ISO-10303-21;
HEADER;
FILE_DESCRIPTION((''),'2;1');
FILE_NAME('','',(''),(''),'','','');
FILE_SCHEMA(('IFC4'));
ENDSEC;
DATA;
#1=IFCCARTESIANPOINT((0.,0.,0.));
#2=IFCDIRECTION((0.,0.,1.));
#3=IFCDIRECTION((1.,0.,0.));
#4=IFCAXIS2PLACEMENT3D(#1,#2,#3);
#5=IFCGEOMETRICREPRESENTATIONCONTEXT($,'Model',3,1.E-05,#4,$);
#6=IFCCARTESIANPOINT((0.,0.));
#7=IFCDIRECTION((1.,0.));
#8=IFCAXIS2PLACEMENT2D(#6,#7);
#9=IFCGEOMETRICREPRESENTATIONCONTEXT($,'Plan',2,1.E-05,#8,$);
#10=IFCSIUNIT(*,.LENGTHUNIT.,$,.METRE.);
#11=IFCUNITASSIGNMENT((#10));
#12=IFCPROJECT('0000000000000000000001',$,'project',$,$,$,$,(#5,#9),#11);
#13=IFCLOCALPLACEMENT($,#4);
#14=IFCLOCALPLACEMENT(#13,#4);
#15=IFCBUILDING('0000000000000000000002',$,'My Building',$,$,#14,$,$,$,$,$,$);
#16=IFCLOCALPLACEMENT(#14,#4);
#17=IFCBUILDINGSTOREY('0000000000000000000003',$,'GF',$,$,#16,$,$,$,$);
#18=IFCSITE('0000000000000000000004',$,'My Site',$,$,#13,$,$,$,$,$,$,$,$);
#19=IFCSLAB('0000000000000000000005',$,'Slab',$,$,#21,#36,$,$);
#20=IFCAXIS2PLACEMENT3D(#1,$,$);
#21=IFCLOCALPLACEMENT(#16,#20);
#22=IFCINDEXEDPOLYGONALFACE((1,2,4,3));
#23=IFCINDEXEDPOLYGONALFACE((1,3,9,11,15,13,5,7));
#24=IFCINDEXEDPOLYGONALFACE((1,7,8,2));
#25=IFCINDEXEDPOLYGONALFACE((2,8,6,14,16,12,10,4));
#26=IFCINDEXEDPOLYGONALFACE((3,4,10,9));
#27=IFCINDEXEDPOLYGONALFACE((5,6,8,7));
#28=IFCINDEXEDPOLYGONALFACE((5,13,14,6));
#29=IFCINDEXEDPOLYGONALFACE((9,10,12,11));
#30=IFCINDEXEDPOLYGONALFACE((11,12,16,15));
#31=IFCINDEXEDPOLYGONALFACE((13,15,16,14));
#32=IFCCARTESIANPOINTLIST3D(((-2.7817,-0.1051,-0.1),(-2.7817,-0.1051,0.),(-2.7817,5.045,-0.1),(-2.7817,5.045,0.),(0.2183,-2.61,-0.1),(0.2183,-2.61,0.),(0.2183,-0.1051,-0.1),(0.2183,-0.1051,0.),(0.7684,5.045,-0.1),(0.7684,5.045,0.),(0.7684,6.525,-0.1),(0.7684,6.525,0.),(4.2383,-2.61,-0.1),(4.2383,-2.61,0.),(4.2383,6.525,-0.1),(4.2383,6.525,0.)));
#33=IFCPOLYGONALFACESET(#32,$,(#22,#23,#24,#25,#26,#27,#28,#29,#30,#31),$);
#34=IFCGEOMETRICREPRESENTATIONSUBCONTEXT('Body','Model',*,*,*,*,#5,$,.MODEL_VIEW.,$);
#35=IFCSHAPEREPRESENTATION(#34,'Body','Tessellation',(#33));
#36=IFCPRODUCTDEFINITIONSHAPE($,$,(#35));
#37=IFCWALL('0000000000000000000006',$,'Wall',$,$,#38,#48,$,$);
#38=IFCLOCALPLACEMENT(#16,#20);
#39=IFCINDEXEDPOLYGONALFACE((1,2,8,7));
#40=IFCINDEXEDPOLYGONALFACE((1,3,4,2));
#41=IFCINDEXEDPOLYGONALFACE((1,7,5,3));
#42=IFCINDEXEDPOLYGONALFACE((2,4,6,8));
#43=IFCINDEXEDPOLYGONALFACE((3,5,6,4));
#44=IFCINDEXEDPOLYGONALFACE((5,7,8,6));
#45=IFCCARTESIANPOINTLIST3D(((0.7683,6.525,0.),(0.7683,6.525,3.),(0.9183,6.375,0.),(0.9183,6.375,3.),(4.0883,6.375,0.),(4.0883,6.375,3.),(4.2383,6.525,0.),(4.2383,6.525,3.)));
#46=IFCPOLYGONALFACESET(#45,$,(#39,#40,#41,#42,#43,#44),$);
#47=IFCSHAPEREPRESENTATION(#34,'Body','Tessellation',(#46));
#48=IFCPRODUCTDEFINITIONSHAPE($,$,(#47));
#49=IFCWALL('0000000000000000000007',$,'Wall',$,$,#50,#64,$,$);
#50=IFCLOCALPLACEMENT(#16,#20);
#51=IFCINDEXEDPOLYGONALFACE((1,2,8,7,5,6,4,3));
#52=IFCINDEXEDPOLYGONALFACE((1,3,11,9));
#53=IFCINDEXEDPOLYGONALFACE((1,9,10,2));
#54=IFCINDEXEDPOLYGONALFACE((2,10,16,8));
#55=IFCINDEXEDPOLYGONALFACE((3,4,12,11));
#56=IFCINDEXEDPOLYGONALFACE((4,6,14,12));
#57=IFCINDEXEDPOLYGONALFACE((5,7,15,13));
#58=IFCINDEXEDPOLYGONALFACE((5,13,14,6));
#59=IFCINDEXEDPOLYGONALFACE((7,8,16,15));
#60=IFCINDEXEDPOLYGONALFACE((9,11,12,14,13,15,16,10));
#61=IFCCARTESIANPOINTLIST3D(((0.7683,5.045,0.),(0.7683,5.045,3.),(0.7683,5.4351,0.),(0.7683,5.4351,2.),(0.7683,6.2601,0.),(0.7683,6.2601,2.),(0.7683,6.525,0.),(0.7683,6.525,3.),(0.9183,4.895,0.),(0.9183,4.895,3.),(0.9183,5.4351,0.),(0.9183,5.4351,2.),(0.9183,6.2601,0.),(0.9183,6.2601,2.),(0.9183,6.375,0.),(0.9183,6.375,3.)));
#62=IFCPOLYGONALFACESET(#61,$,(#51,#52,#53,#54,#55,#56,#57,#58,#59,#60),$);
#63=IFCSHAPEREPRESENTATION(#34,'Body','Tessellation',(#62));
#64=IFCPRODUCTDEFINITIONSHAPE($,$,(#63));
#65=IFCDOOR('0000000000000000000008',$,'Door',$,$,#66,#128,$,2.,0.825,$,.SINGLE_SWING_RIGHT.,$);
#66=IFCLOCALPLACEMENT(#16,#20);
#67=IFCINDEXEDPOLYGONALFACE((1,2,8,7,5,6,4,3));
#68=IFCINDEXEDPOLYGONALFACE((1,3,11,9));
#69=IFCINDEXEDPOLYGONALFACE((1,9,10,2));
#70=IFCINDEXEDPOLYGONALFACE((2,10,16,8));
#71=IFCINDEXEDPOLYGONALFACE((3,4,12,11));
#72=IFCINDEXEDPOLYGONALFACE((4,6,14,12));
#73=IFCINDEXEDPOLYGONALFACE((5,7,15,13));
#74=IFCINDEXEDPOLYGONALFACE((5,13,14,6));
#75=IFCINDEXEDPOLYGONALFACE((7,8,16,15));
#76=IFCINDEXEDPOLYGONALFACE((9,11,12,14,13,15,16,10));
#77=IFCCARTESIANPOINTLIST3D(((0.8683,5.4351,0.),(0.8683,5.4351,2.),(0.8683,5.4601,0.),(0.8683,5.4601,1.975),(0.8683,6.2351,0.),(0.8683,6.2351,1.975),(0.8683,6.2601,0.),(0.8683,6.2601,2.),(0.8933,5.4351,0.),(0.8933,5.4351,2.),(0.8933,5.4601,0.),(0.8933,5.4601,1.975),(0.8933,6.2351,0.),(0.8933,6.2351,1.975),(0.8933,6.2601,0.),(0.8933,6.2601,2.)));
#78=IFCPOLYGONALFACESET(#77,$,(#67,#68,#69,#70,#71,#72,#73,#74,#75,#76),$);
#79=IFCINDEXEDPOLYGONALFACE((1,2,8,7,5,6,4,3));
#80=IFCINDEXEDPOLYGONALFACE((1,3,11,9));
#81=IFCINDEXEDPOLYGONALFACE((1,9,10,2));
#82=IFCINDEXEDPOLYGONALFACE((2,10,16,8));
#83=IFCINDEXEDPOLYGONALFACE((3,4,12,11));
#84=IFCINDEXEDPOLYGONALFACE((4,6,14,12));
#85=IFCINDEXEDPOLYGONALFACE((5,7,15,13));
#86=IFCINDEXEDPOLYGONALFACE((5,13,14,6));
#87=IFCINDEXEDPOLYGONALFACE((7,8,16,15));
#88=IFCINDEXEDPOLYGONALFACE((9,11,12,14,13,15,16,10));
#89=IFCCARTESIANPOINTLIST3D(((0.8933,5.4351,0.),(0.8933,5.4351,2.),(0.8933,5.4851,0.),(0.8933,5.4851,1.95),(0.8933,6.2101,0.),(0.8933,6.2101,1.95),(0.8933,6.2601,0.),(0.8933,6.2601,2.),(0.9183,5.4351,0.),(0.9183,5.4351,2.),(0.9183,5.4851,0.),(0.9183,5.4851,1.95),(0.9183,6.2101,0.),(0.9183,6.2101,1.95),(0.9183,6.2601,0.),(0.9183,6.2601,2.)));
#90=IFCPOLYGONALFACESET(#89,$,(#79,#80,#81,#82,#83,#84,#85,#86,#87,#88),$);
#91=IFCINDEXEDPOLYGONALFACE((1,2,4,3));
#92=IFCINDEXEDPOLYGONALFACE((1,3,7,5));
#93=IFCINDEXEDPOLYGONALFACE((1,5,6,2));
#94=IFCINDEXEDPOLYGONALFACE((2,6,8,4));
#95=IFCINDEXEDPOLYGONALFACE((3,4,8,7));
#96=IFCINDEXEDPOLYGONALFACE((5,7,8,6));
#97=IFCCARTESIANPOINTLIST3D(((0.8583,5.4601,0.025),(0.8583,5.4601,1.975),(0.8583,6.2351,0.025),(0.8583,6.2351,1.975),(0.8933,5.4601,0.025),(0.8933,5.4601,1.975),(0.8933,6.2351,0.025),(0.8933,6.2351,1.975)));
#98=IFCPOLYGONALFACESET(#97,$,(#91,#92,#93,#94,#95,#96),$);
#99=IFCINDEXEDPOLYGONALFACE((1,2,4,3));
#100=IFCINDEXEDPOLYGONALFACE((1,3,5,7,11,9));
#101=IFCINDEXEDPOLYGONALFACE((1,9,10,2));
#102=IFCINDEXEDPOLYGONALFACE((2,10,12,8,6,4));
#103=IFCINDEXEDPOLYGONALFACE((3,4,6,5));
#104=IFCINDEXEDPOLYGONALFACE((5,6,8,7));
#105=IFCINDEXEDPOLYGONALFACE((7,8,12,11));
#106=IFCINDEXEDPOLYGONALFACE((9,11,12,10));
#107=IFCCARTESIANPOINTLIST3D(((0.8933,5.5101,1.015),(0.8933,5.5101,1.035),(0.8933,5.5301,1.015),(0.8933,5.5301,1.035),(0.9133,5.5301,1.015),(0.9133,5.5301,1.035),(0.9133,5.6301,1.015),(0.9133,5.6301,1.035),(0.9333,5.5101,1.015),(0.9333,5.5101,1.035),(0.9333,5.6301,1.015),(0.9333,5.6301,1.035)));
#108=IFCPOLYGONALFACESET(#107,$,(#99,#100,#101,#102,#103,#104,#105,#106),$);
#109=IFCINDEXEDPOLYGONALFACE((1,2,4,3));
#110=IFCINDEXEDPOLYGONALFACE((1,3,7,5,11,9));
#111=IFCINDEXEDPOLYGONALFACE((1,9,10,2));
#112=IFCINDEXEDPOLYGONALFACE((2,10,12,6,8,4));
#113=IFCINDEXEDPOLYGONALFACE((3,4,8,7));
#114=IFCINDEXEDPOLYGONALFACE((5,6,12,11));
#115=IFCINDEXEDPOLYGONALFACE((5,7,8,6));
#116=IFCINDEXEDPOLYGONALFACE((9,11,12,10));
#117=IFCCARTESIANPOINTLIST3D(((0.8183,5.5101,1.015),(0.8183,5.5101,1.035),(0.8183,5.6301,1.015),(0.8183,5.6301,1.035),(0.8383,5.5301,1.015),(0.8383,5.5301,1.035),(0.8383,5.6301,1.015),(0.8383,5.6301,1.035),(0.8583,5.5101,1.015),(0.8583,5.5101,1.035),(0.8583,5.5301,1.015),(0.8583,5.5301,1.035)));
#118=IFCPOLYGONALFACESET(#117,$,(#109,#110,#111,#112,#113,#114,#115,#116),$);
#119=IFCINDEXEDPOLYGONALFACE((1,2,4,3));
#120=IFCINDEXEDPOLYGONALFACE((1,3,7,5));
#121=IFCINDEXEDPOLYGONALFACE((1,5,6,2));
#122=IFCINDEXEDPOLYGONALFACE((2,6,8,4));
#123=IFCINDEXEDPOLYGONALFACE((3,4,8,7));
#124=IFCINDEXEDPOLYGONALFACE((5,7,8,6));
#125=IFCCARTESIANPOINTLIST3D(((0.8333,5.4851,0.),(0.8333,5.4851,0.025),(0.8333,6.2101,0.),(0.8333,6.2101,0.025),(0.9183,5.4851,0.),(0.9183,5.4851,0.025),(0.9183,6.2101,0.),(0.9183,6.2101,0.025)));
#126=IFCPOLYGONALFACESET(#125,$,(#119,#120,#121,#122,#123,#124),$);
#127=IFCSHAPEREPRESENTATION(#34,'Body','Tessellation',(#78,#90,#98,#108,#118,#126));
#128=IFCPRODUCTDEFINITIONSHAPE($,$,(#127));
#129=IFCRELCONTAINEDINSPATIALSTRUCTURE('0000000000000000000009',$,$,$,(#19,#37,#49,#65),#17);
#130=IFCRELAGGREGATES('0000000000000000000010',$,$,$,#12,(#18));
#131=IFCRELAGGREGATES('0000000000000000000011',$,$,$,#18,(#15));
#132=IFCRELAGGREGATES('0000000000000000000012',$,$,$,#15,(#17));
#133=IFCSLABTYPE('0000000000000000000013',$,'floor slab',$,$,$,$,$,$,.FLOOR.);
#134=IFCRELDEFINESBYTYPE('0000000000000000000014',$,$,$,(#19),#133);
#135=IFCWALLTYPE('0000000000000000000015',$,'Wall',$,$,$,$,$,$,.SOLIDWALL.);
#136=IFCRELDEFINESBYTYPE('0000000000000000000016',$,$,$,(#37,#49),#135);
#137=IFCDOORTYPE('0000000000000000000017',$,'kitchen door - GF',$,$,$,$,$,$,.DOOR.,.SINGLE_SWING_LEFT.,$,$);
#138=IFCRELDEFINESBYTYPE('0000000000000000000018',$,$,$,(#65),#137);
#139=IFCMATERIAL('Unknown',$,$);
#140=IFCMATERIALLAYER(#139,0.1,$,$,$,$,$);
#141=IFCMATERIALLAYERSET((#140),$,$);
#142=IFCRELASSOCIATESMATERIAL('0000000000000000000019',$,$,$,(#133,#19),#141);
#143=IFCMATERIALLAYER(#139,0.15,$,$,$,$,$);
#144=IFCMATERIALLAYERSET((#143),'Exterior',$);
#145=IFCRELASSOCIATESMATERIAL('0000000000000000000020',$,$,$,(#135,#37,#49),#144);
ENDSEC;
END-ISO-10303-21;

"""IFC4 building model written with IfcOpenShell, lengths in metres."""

from ifc_helpers import new_model, entity, si_unit, frame, origin_with_axes, origin_2d_with_axis, place, context, subcontext, project, spatial, line, indexed_curve, outline, extrude, shape, source, transform, mapped, material, layer, layer_set, layer_usage, type_object, type_shapes, element, fill, save


model = new_model("IFC4")

# Units and contexts
model_context = context("Model", 3, precision=1e-05, world=origin_with_axes())
plan_context = context("Plan", 2, precision=1e-05, world=origin_2d_with_axis())
body_context_1 = subcontext(model_context, "Body", "Model", "MODEL_VIEW")
body_context_2 = subcontext(plan_context, "Body", "Plan", "PLAN_VIEW")
ifc_project = project(units=[si_unit("LENGTHUNIT", "METRE")], contexts=[model_context, plan_context])

# Site, building, storey
site_placement = place(None, origin_with_axes())
site = spatial("IfcSite", under=ifc_project, at=site_placement, Name="My Site")
building_placement = place(site_placement, origin_with_axes())
building = spatial("IfcBuilding", under=site, at=building_placement, Name="My Building")
storey_placement = place(building_placement, origin_with_axes())
storey = spatial("IfcBuildingStorey", under=building, at=storey_placement, Name="GF")

# Slab
ifc_material = material(Name="Unknown")
ifc_layer_1 = layer(ifc_material, 0.1)
ifc_layer_set_1 = layer_set([ifc_layer_1])
ifc_layer_usage_1 = layer_usage(ifc_layer_set_1, "AXIS3", "POSITIVE", -0.1)
slab_type_1 = type_object("IfcSlabType", Name="floor slab", PredefinedType="FLOOR", material=ifc_layer_set_1)
slab_1_placement = place(storey_placement, frame((4.2383, -2.61, 0.0), z_axis=(0.0, 0.0, 1.0), x_axis=(1.0, 0.0, 0.0)))
element("IfcSlab", 1, at=slab_1_placement, inside=storey, type_object=slab_type_1, material=ifc_layer_usage_1, Name="Slab", context=body_context_1, shape_type="SweptSolid", body=[
    extrude(outline(indexed_curve([(0.0, 0.0), (0.0, 9.135), (-3.47, 9.135), (-3.47, 7.655), (-7.02, 7.655), (-7.02, 2.5049), (-4.02, 2.5049), (-4.02, 0.0), (0.0, 0.0)])), frame((0.0, 0.0, -0.1), z_axis=(0.0, 0.0, 1.0), x_axis=(1.0, 0.0, 0.0)), (0.0, 0.0, 1.0), 0.1),
])

# Shared definitions
ifc_layer_2 = layer(ifc_material, 0.15)
ifc_layer_set_2 = layer_set([ifc_layer_2], Name="Exterior")
wall_type_1 = type_object("IfcWallType", Name="Wall", PredefinedType="SOLIDWALL", material=ifc_layer_set_2)

# Wall
ifc_layer_usage_2 = layer_usage(ifc_layer_set_2, "AXIS2", "POSITIVE", 0.0)
wall_1_placement = place(storey_placement, frame((4.2383, 6.525, 0.0), z_axis=(0.0, 0.0, 1.0), x_axis=(-1.0, 0.0, 0.0)))
element("IfcWall", 2, at=wall_1_placement, inside=storey, type_object=wall_type_1, material=ifc_layer_usage_2, Name="Wall", context=body_context_1, shape_type="SweptSolid", body=[
    extrude(outline(indexed_curve([(0.0, 0.0), (0.15, 0.15), (3.32, 0.15), (3.47, 0.0)], segments=[line(1, 2, 3, 4, 1)])), origin_with_axes(), (0.0, 0.0, 1.0), 3.0),
])

# Wall, opening, door
ifc_layer_usage_3 = layer_usage(ifc_layer_set_2, "AXIS2", "POSITIVE", 0.0)
wall_2_placement = place(storey_placement, frame((0.7683, 6.525, 0.0), z_axis=(0.0, 0.0, 1.0), x_axis=(0.0, -1.0, 0.0)))
wall_2 = element("IfcWall", 3, at=wall_2_placement, inside=storey, type_object=wall_type_1, material=ifc_layer_usage_3, Name="Wall", context=body_context_1, shape_type="SweptSolid", body=[
    extrude(outline(indexed_curve([(0.0, 0.0), (0.15, 0.15), (1.63, 0.15), (1.48, 0.0)], segments=[line(1, 2, 3, 4, 1)])), origin_with_axes(), (0.0, 0.0, 1.0), 3.0),
])
shared_shape_1 = source(origin_with_axes(), body_context_1, "Body", "SweptSolid", [
    extrude(outline(indexed_curve([(0.0, 0.0), (0.825, 0.0), (0.825, 2.0), (0.0, 2.0)], segments=[line(1, 2, 3, 4, 1)])), frame((0.0, -0.6, 0.0), z_axis=(0.0, -1.0, 0.0), x_axis=(1.0, 0.0, 0.0)), (0.0, 0.0, -1.0), 1.2),
])
opening_1_placement = place(wall_2_placement, frame((1.0898, 0.15, 0.0), z_axis=(0.0, 0.0, 1.0), x_axis=(-1.0, 0.0, 0.0)))
opening_1 = element("IfcOpeningElement", 4, at=opening_1_placement, cuts=wall_2, PredefinedType="OPENING", context=body_context_1, shape_type="MappedRepresentation", body=[
    mapped(shared_shape_1, transform((0.0, 0.0, 0.0), x_axis=(1.0, 0.0, 0.0), y_axis=(0.0, 1.0, 0.0), z_axis=(0.0, 0.0, 1.0), scale=1.0)),
])
door_type_1 = type_object("IfcDoorType", Name="kitchen door - GF", OperationType="SINGLE_SWING_LEFT", PredefinedType="DOOR")
shared_shape_2 = source(origin_with_axes(), body_context_1, "Body", "SweptSolid", [
    extrude(outline(indexed_curve([(0.0, 0.0), (0.0, 2.0), (0.825, 2.0), (0.825, 0.0), (0.8, 0.0), (0.8, 1.975), (0.025, 1.975), (0.025, 0.0)], segments=[line(1, 2, 3, 4, 5, 6, 7, 8, 1)])), frame((0.0, 0.025, 0.0), z_axis=(0.0, -1.0, 0.0), x_axis=(1.0, 0.0, 0.0)), (0.0, 0.0, -1.0), 0.025),
    extrude(outline(indexed_curve([(0.0, 0.0), (0.0, 2.0), (0.825, 2.0), (0.825, 0.0), (0.775, 0.0), (0.775, 1.95), (0.05, 1.95), (0.05, 0.0)], segments=[line(1, 2, 3, 4, 5, 6, 7, 8, 1)])), frame((0.0, 0.0, 0.0), z_axis=(0.0, -1.0, 0.0), x_axis=(1.0, 0.0, 0.0)), (0.0, 0.0, -1.0), 0.025),
    extrude(outline(indexed_curve([(0.0, 0.0), (0.775, 0.0), (0.775, 0.035), (0.0, 0.035)], segments=[line(1, 2, 3, 4, 1)])), frame((0.025, 0.025, 0.025), z_axis=(0.0, 0.0, 1.0), x_axis=(1.0, 0.0, 0.0)), (0.0, 0.0, 1.0), 1.95),
    extrude(outline(indexed_curve([(0.0, 0.0), (0.0, -0.04), (0.12, -0.04), (0.12, -0.02), (0.02, -0.02), (0.02, 0.0)], segments=[line(1, 2, 3, 4, 5, 6, 1)])), frame((0.075, 0.025, 1.015), z_axis=(0.0, 0.0, 1.0), x_axis=(1.0, 0.0, 0.0)), (0.0, 0.0, 1.0), 0.02),
    extrude(outline(indexed_curve([(0.0, 0.0), (0.0, 0.04), (0.12, 0.04), (0.12, 0.02), (0.02, 0.02), (0.02, 0.0)], segments=[line(1, 2, 3, 4, 5, 6, 1)])), frame((0.075, 0.06, 1.015), z_axis=(0.0, 0.0, 1.0), x_axis=(1.0, 0.0, 0.0)), (0.0, 0.0, 1.0), 0.02),
    extrude(outline(indexed_curve([(0.0, 0.0), (0.725, 0.0), (0.725, 0.085), (0.0, 0.085)], segments=[line(1, 2, 3, 4, 1)])), frame((0.05, 0.0, 0.0), z_axis=(0.0, 0.0, 1.0), x_axis=(1.0, 0.0, 0.0)), (0.0, 0.0, 1.0), 0.025),
])
shared_shape_3 = source(origin_with_axes(), body_context_2, "Body", "Curve2D", [
    entity("IfcIndexedPolyCurve", entity("IfcCartesianPointList2D", [[0.0, 0.0], [0.0, 0.05], [0.025, 0.05], [0.025, 0.025], [0.05, 0.025], [0.05, 0.0]]), [entity("IfcLineIndex", [1, 2, 3, 4, 5, 6, 1])]),
    entity("IfcIndexedPolyCurve", entity("IfcCartesianPointList2D", [[0.825, 0.0], [0.825, 0.05], [0.8, 0.05], [0.8, 0.025], [0.775, 0.025], [0.775, 0.0]]), [entity("IfcLineIndex", [1, 2, 3, 4, 5, 6, 1])]),
    entity("IfcTrimmedCurve", entity("IfcEllipse", entity("IfcAxis2Placement2D", entity("IfcCartesianPoint", [0.765, 0.05]), entity("IfcDirection", [1.0, 0.0])), 0.74, 0.775), [entity("IfcCartesianPoint", [0.765, 0.825])], [entity("IfcCartesianPoint", [0.025, 0.05])], True, "CARTESIAN"),
    entity("IfcIndexedPolyCurve", entity("IfcCartesianPointList2D", [[0.8, 0.05], [0.765, 0.05], [0.765, 0.825], [0.8, 0.825]]), [entity("IfcLineIndex", [1, 2, 3, 4, 1])]),
])
type_shapes(door_type_1, [shared_shape_2, shared_shape_3])
door_1_placement = place(opening_1_placement, frame((0.0, 0.0, 0.0), z_axis=(0.0, 0.0, 1.0), x_axis=(1.0, 0.0, 0.0)))
door_1 = element("IfcDoor", 5, at=door_1_placement, inside=storey, type_object=door_type_1, Name="Door", OperationType="SINGLE_SWING_RIGHT", OverallHeight=2.0, OverallWidth=0.825, shapes=[
    shape(body_context_1, "Body", "MappedRepresentation", [mapped(shared_shape_2, transform((0.0, 0.0, 0.0), x_axis=(1.0, 0.0, 0.0), y_axis=(0.0, 1.0, 0.0), z_axis=(0.0, 0.0, 1.0), scale=1.0))]),
    shape(body_context_2, "Body", "MappedRepresentation", [mapped(shared_shape_3, transform((0.0, 0.0, 0.0), x_axis=(1.0, 0.0, 0.0), y_axis=(0.0, 1.0, 0.0), z_axis=(0.0, 0.0, 1.0), scale=1.0))]),
])
fill(opening_1, door_1)

save(model, "model.ifc")
